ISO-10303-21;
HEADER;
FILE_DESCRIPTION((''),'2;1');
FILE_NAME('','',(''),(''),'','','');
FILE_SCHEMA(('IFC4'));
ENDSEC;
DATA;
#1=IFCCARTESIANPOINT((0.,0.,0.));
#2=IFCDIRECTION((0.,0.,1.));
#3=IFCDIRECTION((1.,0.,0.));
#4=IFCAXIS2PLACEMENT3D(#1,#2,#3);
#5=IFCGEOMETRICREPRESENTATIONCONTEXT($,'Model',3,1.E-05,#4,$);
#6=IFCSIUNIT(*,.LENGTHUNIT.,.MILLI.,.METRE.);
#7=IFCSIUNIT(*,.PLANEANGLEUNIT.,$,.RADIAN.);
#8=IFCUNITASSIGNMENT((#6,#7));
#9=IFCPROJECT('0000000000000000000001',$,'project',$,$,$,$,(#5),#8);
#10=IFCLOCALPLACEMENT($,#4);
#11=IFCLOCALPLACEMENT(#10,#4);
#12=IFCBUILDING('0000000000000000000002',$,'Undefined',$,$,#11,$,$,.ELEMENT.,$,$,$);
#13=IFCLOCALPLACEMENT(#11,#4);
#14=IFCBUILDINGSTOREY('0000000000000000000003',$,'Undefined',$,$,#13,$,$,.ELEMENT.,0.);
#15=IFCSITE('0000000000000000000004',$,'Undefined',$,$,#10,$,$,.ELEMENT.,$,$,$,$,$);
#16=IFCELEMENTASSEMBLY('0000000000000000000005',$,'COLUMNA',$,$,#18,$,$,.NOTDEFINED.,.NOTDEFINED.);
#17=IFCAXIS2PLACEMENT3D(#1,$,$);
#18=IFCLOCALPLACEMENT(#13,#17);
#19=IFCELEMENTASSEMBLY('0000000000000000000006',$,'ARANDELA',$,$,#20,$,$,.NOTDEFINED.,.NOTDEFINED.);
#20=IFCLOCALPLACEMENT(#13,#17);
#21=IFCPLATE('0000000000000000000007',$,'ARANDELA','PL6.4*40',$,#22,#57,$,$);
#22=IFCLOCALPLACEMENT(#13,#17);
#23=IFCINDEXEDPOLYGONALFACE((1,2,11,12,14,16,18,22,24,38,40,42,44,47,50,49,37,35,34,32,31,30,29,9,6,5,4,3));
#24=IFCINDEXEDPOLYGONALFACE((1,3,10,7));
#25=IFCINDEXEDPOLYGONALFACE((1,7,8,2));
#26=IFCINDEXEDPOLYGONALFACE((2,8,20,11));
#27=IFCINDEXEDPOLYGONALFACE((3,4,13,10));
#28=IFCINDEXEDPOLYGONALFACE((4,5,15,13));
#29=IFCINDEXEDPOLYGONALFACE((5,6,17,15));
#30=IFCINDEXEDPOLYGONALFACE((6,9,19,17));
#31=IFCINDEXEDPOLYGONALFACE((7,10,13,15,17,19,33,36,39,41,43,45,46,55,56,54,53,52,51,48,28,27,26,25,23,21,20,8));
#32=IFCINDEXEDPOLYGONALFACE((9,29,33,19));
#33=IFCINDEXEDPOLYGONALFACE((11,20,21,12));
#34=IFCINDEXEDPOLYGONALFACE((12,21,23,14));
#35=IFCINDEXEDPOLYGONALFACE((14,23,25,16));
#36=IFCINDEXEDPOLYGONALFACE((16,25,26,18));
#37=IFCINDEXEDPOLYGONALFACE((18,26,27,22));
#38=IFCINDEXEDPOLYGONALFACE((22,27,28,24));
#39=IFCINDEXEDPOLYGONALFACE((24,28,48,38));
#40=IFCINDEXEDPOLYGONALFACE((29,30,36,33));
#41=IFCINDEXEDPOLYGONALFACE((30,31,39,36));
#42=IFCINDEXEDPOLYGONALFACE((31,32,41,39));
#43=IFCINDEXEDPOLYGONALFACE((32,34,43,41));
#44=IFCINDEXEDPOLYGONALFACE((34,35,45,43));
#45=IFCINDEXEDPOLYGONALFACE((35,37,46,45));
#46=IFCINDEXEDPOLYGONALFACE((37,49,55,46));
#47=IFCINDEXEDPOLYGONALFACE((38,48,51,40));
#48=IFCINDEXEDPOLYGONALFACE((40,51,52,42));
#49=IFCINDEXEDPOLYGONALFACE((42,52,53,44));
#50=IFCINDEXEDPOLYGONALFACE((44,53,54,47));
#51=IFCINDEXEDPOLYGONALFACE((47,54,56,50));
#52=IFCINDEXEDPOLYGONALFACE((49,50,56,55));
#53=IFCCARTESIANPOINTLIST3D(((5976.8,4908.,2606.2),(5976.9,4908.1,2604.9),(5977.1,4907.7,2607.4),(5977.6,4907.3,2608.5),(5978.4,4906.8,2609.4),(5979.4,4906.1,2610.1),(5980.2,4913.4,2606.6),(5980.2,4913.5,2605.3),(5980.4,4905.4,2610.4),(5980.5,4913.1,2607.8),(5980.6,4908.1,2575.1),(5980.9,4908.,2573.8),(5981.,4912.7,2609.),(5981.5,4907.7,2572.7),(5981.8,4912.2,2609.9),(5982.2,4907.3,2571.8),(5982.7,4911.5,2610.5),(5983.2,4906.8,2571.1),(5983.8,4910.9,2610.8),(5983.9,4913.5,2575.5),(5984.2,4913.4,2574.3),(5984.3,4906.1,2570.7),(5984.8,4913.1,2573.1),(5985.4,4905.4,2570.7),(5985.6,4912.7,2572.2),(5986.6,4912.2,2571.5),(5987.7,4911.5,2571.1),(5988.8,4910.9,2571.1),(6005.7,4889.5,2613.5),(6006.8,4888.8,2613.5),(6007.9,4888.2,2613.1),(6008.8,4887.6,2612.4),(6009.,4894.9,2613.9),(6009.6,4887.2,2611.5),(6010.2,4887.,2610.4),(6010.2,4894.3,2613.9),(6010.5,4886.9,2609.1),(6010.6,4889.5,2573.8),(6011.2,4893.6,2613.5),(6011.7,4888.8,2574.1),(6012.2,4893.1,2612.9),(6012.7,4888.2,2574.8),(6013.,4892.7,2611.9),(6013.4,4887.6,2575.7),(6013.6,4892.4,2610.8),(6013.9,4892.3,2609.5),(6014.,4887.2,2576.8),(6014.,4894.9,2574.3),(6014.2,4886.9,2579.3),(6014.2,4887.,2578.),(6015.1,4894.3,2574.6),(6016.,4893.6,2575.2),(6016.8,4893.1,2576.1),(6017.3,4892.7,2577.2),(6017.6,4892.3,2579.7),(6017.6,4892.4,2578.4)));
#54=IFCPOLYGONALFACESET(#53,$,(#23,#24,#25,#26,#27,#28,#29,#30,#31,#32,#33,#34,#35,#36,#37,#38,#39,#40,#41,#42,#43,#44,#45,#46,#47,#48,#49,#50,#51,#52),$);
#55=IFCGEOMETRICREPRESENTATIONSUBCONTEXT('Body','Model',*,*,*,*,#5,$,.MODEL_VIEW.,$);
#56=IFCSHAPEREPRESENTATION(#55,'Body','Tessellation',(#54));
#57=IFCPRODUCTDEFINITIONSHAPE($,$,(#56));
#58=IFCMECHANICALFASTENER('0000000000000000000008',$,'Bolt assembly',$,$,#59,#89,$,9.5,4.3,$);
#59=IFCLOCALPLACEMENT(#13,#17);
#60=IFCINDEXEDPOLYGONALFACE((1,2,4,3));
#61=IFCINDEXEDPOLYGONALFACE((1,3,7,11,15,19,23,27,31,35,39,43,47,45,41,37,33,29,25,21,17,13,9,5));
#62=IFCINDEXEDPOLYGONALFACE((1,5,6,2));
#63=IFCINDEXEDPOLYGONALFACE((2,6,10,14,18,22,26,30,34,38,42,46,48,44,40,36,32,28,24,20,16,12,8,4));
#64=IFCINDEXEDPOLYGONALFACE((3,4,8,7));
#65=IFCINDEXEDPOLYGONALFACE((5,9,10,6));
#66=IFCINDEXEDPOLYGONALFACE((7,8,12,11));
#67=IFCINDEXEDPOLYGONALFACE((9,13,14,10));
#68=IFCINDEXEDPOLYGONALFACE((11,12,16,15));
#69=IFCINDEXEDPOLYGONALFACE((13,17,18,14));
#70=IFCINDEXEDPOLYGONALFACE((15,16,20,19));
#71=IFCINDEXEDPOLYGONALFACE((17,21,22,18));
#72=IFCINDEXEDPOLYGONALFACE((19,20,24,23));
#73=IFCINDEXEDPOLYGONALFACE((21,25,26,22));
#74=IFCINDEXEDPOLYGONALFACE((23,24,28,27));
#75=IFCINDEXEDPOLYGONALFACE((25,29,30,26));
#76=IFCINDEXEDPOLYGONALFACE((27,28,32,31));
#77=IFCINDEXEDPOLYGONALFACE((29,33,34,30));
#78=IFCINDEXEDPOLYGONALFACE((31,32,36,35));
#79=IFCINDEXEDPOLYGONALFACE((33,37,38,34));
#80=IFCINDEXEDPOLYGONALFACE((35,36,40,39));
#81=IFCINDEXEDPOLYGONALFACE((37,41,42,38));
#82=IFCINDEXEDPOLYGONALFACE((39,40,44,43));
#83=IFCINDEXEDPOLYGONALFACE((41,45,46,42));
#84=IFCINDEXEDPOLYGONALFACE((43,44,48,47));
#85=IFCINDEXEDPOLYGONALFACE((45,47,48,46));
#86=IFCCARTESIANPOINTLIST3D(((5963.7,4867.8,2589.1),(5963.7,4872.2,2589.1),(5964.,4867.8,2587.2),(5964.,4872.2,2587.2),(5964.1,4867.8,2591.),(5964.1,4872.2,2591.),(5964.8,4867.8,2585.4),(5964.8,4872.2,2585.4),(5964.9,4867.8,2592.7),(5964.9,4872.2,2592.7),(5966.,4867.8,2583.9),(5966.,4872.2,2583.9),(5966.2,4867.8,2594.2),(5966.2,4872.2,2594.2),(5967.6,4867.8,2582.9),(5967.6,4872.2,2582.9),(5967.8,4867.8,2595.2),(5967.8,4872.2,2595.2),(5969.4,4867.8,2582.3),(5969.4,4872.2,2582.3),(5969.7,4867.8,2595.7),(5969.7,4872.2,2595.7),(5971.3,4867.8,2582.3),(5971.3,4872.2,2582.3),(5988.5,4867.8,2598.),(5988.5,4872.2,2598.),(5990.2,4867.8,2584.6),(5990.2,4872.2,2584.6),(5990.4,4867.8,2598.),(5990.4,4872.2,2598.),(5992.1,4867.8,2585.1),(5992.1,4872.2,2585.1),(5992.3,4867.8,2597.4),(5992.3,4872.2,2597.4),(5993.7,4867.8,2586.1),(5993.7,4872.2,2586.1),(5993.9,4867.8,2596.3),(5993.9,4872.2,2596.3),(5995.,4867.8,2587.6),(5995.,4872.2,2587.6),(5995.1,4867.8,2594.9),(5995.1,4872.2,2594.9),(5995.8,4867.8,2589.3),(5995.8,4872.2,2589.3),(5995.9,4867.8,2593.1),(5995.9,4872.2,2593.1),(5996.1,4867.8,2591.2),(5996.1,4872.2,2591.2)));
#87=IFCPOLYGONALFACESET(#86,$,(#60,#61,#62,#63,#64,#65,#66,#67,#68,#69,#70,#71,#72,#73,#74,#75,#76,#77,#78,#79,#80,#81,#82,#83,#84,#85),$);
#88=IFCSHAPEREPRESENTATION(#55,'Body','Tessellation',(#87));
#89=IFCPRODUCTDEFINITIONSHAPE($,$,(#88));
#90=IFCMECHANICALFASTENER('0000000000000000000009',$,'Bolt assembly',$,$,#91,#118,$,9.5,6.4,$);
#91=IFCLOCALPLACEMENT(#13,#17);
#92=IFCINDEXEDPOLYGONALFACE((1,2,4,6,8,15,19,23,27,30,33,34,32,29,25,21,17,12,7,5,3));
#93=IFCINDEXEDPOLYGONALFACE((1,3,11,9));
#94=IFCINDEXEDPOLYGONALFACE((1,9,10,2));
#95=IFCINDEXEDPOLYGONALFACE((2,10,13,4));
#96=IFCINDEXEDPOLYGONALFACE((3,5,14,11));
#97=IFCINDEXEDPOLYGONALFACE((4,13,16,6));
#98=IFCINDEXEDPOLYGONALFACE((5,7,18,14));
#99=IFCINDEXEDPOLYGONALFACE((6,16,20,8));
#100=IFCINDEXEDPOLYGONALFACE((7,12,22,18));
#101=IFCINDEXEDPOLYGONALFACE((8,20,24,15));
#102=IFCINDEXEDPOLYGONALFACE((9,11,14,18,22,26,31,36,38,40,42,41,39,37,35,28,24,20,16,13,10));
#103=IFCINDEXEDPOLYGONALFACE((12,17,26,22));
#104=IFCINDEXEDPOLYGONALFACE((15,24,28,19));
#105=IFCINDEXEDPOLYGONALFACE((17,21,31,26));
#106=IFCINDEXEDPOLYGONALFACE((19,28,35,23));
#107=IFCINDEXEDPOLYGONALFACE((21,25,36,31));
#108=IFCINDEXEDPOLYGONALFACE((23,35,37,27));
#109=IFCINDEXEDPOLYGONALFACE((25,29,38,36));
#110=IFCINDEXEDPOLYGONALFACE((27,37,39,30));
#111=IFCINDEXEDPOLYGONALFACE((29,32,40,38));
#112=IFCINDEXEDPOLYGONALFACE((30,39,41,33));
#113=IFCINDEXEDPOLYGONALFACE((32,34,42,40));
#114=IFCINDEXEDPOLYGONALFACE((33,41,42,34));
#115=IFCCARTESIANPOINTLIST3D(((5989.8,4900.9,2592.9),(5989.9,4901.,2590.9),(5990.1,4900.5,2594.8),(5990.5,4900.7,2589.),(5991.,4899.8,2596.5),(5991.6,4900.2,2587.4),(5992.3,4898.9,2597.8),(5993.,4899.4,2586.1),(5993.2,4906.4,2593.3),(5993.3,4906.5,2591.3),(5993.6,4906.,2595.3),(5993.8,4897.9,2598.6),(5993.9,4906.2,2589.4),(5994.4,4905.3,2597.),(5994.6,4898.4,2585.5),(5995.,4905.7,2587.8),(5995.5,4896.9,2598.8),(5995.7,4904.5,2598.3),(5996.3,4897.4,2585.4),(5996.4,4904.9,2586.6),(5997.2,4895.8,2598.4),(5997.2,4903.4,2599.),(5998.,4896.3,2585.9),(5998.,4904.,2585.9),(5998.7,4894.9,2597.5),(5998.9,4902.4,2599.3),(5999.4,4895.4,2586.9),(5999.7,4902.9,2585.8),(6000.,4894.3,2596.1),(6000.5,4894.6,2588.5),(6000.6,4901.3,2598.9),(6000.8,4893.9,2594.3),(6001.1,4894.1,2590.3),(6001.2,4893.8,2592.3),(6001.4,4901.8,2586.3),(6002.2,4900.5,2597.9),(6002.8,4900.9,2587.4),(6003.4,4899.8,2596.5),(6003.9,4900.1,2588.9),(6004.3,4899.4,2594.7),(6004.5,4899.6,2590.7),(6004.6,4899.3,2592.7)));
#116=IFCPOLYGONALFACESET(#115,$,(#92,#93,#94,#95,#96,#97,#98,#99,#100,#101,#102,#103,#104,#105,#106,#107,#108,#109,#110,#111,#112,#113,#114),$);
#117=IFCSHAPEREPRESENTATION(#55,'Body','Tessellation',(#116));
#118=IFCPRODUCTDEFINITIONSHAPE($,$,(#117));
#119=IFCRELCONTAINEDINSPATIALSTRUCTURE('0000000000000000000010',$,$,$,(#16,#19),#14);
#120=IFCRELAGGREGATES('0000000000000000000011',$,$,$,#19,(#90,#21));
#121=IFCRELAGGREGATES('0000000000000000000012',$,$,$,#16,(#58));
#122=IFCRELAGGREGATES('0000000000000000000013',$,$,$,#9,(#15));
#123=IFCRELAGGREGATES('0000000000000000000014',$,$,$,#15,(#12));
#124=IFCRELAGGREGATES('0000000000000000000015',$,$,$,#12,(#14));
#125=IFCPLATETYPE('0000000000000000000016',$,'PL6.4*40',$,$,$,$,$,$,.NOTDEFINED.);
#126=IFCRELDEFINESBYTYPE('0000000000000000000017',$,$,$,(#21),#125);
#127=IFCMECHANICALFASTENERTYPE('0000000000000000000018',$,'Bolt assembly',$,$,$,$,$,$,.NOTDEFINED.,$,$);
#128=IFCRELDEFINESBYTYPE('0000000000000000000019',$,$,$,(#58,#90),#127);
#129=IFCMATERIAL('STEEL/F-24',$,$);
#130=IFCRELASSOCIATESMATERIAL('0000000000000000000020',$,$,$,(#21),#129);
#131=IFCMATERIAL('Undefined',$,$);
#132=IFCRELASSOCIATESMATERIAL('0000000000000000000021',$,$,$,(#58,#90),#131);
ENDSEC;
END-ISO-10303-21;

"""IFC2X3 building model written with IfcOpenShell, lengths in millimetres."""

from ifc_helpers import new_model, si_unit, frame, frame_2d, origin_with_axes, origin_2d_with_axis, place, context, subcontext, project, spatial, polyline, circle_curve, parameter, trimmed, segment, composite_curve, circle, outline, extrude, source, transform, mapped, material, type_object, element, aggregate, save


model = new_model("IFC2X3")

# Units and contexts
model_context = context("Model", 3, precision=1e-05, world=origin_with_axes())
body_context = subcontext(model_context, "Body", "Model", "MODEL_VIEW")
ifc_project = project(units=[si_unit("LENGTHUNIT", "METRE", prefix="MILLI"), si_unit("PLANEANGLEUNIT", "RADIAN")], contexts=[model_context])

# Site, building, storey
site_placement = place(None, origin_with_axes())
site = spatial("IfcSite", under=ifc_project, at=site_placement, Name="Undefined", CompositionType="ELEMENT")
building_placement = place(site_placement, origin_with_axes())
building = spatial("IfcBuilding", under=site, at=building_placement, Name="Undefined", CompositionType="ELEMENT")
storey_placement = place(building_placement, origin_with_axes())
storey = spatial("IfcBuildingStorey", under=building, at=storey_placement, Name="Undefined", CompositionType="ELEMENT", Elevation=0.0)

# Shared definitions
ifc_material_1 = material(Name="STEEL/F-24")

# Element assembly
assembly_1_placement = place(storey_placement, origin_with_axes())
assembly_1 = element("IfcElementAssembly", 1, at=assembly_1_placement, inside=storey, Name="COLUMNA", AssemblyPlace="NOTDEFINED", PredefinedType="NOTDEFINED")

# Element assembly, plate
assembly_2_placement = place(storey_placement, origin_with_axes())
assembly_2 = element("IfcElementAssembly", 2, at=assembly_2_placement, inside=storey, Name="ARANDELA", AssemblyPlace="NOTDEFINED", PredefinedType="NOTDEFINED")
plate_type_1 = type_object("IfcPlateType", Name="PL6.4*40", PredefinedType="NOTDEFINED")
plate_1_placement = place(assembly_2_placement, frame((5977.9, 4910.8, 2610.0), z_axis=(0.526076, 0.84789, 0.065781), x_axis=(0.841338, -0.530172, 0.105202)))
plate_1 = element("IfcPlate", 3, at=plate_1_placement, type_object=plate_type_1, material=ifc_material_1, Name="ARANDELA", Description="PL6.4*40", context=body_context, shape_type="SweptSolid", body=[
    extrude(outline(composite_curve([segment(trimmed(circle_curve(frame_2d((5.0, 5.0), x_axis=(-1.0, 0.0)), 5.0), [parameter(0.0)], [parameter(1.570796)], True, "PARAMETER"), True, "CONTINUOUS"), segment(polyline([(5.0, 0.0), (35.0, 0.0)]), True, "CONTINUOUS"), segment(trimmed(circle_curve(frame_2d((35.0, 5.0), x_axis=(0.0, -1.0)), 5.0), [parameter(0.0)], [parameter(1.570796)], True, "PARAMETER"), True, "CONTINUOUS"), segment(polyline([(40.0, 5.0), (40.0, 35.0)]), True, "CONTINUOUS"), segment(trimmed(circle_curve(frame_2d((35.0, 35.0), x_axis=(1.0, 0.0)), 5.0), [parameter(0.0)], [parameter(1.570796)], True, "PARAMETER"), True, "CONTINUOUS"), segment(polyline([(35.0, 40.0), (5.0, 40.0)]), True, "CONTINUOUS"), segment(trimmed(circle_curve(frame_2d((5.0, 35.0), x_axis=(0.0, 1.0)), 5.0), [parameter(0.0)], [parameter(1.570796)], True, "PARAMETER"), True, "CONTINUOUS"), segment(polyline([(0.0, 35.0), (0.0, 5.0)]), True, "CONTINUOUS")], self_intersect=True)), frame((0.0, 0.0, -3.2), z_axis=(0.0, 0.0, 1.0), x_axis=(1.0, 0.0, 0.0)), (0.0, 0.0, 1.0), 6.4),
])

# Mechanical fasteners
ifc_material_2 = material(Name="Undefined")
mechanical_fastener_type = type_object("IfcMechanicalFastenerType", Name="Bolt assembly")
shared_shape_1 = source(origin_with_axes(), body_context, "Body", "SweptSolid", [
    extrude(outline(composite_curve([segment(polyline([(-9.5, 6.8), (9.5, 6.8)]), True, "CONTINUOUS"), segment(trimmed(circle_curve(frame_2d((9.5, 0.0), x_axis=(0.0, 1.0)), 6.8), [parameter(0.0)], [parameter(3.141593)], False, "PARAMETER"), True, "CONTINUOUS"), segment(polyline([(9.5, -6.8), (-9.5, -6.8)]), True, "CONTINUOUS"), segment(trimmed(circle_curve(frame_2d((-9.5, 0.0), x_axis=(0.0, -1.0)), 6.8), [parameter(0.0)], [parameter(3.141593)], False, "PARAMETER"), True, "DISCONTINUOUS")], self_intersect=False)), frame((0.0, 0.0, 0.0), z_axis=(0.0, 1.0, 0.0), x_axis=(1.0, 0.0, 0.0)), (0.0, 0.0, 1.0), 4.4),
])
mechanical_fastener_1_placement = place(assembly_1_placement, frame((5979.9, 4872.2, 2590.1), z_axis=(-0.124075, 0.0, 0.992273), x_axis=(-0.992273, 0.0, -0.124075)))
mechanical_fastener_1 = element("IfcMechanicalFastener", 4, at=mechanical_fastener_1_placement, type_object=mechanical_fastener_type, material=ifc_material_2, Name="Bolt assembly", NominalDiameter=9.5, NominalLength=4.3, context=body_context, shape_type="MappedRepresentation", body=[
    mapped(shared_shape_1, transform((0.0, 0.0, 0.0))),
])
shared_shape_2 = source(origin_with_axes(), body_context, "Body", "SweptSolid", [
    extrude(circle(Radius=6.8, at=origin_2d_with_axis()), frame((0.0, -6.4, 0.0), z_axis=(0.0, 1.0, 0.0), x_axis=(1.0, 0.0, 0.0)), (0.0, 0.0, 1.0), 6.5),
])
mechanical_fastener_2_placement = place(assembly_2_placement, frame((5995.5, 4897.5, 2592.1), z_axis=(-0.841338, 0.530172, -0.105202), x_axis=(0.124075, 0.0, -0.992273)))
mechanical_fastener_2 = element("IfcMechanicalFastener", 5, at=mechanical_fastener_2_placement, type_object=mechanical_fastener_type, material=ifc_material_2, Name="Bolt assembly", NominalDiameter=9.5, NominalLength=6.4, context=body_context, shape_type="MappedRepresentation", body=[
    mapped(shared_shape_2, transform((0.0, 0.0, 0.0))),
])
aggregate(assembly_2, [mechanical_fastener_2, plate_1])

aggregate(assembly_1, [mechanical_fastener_1])

save(model, "model.ifc")
